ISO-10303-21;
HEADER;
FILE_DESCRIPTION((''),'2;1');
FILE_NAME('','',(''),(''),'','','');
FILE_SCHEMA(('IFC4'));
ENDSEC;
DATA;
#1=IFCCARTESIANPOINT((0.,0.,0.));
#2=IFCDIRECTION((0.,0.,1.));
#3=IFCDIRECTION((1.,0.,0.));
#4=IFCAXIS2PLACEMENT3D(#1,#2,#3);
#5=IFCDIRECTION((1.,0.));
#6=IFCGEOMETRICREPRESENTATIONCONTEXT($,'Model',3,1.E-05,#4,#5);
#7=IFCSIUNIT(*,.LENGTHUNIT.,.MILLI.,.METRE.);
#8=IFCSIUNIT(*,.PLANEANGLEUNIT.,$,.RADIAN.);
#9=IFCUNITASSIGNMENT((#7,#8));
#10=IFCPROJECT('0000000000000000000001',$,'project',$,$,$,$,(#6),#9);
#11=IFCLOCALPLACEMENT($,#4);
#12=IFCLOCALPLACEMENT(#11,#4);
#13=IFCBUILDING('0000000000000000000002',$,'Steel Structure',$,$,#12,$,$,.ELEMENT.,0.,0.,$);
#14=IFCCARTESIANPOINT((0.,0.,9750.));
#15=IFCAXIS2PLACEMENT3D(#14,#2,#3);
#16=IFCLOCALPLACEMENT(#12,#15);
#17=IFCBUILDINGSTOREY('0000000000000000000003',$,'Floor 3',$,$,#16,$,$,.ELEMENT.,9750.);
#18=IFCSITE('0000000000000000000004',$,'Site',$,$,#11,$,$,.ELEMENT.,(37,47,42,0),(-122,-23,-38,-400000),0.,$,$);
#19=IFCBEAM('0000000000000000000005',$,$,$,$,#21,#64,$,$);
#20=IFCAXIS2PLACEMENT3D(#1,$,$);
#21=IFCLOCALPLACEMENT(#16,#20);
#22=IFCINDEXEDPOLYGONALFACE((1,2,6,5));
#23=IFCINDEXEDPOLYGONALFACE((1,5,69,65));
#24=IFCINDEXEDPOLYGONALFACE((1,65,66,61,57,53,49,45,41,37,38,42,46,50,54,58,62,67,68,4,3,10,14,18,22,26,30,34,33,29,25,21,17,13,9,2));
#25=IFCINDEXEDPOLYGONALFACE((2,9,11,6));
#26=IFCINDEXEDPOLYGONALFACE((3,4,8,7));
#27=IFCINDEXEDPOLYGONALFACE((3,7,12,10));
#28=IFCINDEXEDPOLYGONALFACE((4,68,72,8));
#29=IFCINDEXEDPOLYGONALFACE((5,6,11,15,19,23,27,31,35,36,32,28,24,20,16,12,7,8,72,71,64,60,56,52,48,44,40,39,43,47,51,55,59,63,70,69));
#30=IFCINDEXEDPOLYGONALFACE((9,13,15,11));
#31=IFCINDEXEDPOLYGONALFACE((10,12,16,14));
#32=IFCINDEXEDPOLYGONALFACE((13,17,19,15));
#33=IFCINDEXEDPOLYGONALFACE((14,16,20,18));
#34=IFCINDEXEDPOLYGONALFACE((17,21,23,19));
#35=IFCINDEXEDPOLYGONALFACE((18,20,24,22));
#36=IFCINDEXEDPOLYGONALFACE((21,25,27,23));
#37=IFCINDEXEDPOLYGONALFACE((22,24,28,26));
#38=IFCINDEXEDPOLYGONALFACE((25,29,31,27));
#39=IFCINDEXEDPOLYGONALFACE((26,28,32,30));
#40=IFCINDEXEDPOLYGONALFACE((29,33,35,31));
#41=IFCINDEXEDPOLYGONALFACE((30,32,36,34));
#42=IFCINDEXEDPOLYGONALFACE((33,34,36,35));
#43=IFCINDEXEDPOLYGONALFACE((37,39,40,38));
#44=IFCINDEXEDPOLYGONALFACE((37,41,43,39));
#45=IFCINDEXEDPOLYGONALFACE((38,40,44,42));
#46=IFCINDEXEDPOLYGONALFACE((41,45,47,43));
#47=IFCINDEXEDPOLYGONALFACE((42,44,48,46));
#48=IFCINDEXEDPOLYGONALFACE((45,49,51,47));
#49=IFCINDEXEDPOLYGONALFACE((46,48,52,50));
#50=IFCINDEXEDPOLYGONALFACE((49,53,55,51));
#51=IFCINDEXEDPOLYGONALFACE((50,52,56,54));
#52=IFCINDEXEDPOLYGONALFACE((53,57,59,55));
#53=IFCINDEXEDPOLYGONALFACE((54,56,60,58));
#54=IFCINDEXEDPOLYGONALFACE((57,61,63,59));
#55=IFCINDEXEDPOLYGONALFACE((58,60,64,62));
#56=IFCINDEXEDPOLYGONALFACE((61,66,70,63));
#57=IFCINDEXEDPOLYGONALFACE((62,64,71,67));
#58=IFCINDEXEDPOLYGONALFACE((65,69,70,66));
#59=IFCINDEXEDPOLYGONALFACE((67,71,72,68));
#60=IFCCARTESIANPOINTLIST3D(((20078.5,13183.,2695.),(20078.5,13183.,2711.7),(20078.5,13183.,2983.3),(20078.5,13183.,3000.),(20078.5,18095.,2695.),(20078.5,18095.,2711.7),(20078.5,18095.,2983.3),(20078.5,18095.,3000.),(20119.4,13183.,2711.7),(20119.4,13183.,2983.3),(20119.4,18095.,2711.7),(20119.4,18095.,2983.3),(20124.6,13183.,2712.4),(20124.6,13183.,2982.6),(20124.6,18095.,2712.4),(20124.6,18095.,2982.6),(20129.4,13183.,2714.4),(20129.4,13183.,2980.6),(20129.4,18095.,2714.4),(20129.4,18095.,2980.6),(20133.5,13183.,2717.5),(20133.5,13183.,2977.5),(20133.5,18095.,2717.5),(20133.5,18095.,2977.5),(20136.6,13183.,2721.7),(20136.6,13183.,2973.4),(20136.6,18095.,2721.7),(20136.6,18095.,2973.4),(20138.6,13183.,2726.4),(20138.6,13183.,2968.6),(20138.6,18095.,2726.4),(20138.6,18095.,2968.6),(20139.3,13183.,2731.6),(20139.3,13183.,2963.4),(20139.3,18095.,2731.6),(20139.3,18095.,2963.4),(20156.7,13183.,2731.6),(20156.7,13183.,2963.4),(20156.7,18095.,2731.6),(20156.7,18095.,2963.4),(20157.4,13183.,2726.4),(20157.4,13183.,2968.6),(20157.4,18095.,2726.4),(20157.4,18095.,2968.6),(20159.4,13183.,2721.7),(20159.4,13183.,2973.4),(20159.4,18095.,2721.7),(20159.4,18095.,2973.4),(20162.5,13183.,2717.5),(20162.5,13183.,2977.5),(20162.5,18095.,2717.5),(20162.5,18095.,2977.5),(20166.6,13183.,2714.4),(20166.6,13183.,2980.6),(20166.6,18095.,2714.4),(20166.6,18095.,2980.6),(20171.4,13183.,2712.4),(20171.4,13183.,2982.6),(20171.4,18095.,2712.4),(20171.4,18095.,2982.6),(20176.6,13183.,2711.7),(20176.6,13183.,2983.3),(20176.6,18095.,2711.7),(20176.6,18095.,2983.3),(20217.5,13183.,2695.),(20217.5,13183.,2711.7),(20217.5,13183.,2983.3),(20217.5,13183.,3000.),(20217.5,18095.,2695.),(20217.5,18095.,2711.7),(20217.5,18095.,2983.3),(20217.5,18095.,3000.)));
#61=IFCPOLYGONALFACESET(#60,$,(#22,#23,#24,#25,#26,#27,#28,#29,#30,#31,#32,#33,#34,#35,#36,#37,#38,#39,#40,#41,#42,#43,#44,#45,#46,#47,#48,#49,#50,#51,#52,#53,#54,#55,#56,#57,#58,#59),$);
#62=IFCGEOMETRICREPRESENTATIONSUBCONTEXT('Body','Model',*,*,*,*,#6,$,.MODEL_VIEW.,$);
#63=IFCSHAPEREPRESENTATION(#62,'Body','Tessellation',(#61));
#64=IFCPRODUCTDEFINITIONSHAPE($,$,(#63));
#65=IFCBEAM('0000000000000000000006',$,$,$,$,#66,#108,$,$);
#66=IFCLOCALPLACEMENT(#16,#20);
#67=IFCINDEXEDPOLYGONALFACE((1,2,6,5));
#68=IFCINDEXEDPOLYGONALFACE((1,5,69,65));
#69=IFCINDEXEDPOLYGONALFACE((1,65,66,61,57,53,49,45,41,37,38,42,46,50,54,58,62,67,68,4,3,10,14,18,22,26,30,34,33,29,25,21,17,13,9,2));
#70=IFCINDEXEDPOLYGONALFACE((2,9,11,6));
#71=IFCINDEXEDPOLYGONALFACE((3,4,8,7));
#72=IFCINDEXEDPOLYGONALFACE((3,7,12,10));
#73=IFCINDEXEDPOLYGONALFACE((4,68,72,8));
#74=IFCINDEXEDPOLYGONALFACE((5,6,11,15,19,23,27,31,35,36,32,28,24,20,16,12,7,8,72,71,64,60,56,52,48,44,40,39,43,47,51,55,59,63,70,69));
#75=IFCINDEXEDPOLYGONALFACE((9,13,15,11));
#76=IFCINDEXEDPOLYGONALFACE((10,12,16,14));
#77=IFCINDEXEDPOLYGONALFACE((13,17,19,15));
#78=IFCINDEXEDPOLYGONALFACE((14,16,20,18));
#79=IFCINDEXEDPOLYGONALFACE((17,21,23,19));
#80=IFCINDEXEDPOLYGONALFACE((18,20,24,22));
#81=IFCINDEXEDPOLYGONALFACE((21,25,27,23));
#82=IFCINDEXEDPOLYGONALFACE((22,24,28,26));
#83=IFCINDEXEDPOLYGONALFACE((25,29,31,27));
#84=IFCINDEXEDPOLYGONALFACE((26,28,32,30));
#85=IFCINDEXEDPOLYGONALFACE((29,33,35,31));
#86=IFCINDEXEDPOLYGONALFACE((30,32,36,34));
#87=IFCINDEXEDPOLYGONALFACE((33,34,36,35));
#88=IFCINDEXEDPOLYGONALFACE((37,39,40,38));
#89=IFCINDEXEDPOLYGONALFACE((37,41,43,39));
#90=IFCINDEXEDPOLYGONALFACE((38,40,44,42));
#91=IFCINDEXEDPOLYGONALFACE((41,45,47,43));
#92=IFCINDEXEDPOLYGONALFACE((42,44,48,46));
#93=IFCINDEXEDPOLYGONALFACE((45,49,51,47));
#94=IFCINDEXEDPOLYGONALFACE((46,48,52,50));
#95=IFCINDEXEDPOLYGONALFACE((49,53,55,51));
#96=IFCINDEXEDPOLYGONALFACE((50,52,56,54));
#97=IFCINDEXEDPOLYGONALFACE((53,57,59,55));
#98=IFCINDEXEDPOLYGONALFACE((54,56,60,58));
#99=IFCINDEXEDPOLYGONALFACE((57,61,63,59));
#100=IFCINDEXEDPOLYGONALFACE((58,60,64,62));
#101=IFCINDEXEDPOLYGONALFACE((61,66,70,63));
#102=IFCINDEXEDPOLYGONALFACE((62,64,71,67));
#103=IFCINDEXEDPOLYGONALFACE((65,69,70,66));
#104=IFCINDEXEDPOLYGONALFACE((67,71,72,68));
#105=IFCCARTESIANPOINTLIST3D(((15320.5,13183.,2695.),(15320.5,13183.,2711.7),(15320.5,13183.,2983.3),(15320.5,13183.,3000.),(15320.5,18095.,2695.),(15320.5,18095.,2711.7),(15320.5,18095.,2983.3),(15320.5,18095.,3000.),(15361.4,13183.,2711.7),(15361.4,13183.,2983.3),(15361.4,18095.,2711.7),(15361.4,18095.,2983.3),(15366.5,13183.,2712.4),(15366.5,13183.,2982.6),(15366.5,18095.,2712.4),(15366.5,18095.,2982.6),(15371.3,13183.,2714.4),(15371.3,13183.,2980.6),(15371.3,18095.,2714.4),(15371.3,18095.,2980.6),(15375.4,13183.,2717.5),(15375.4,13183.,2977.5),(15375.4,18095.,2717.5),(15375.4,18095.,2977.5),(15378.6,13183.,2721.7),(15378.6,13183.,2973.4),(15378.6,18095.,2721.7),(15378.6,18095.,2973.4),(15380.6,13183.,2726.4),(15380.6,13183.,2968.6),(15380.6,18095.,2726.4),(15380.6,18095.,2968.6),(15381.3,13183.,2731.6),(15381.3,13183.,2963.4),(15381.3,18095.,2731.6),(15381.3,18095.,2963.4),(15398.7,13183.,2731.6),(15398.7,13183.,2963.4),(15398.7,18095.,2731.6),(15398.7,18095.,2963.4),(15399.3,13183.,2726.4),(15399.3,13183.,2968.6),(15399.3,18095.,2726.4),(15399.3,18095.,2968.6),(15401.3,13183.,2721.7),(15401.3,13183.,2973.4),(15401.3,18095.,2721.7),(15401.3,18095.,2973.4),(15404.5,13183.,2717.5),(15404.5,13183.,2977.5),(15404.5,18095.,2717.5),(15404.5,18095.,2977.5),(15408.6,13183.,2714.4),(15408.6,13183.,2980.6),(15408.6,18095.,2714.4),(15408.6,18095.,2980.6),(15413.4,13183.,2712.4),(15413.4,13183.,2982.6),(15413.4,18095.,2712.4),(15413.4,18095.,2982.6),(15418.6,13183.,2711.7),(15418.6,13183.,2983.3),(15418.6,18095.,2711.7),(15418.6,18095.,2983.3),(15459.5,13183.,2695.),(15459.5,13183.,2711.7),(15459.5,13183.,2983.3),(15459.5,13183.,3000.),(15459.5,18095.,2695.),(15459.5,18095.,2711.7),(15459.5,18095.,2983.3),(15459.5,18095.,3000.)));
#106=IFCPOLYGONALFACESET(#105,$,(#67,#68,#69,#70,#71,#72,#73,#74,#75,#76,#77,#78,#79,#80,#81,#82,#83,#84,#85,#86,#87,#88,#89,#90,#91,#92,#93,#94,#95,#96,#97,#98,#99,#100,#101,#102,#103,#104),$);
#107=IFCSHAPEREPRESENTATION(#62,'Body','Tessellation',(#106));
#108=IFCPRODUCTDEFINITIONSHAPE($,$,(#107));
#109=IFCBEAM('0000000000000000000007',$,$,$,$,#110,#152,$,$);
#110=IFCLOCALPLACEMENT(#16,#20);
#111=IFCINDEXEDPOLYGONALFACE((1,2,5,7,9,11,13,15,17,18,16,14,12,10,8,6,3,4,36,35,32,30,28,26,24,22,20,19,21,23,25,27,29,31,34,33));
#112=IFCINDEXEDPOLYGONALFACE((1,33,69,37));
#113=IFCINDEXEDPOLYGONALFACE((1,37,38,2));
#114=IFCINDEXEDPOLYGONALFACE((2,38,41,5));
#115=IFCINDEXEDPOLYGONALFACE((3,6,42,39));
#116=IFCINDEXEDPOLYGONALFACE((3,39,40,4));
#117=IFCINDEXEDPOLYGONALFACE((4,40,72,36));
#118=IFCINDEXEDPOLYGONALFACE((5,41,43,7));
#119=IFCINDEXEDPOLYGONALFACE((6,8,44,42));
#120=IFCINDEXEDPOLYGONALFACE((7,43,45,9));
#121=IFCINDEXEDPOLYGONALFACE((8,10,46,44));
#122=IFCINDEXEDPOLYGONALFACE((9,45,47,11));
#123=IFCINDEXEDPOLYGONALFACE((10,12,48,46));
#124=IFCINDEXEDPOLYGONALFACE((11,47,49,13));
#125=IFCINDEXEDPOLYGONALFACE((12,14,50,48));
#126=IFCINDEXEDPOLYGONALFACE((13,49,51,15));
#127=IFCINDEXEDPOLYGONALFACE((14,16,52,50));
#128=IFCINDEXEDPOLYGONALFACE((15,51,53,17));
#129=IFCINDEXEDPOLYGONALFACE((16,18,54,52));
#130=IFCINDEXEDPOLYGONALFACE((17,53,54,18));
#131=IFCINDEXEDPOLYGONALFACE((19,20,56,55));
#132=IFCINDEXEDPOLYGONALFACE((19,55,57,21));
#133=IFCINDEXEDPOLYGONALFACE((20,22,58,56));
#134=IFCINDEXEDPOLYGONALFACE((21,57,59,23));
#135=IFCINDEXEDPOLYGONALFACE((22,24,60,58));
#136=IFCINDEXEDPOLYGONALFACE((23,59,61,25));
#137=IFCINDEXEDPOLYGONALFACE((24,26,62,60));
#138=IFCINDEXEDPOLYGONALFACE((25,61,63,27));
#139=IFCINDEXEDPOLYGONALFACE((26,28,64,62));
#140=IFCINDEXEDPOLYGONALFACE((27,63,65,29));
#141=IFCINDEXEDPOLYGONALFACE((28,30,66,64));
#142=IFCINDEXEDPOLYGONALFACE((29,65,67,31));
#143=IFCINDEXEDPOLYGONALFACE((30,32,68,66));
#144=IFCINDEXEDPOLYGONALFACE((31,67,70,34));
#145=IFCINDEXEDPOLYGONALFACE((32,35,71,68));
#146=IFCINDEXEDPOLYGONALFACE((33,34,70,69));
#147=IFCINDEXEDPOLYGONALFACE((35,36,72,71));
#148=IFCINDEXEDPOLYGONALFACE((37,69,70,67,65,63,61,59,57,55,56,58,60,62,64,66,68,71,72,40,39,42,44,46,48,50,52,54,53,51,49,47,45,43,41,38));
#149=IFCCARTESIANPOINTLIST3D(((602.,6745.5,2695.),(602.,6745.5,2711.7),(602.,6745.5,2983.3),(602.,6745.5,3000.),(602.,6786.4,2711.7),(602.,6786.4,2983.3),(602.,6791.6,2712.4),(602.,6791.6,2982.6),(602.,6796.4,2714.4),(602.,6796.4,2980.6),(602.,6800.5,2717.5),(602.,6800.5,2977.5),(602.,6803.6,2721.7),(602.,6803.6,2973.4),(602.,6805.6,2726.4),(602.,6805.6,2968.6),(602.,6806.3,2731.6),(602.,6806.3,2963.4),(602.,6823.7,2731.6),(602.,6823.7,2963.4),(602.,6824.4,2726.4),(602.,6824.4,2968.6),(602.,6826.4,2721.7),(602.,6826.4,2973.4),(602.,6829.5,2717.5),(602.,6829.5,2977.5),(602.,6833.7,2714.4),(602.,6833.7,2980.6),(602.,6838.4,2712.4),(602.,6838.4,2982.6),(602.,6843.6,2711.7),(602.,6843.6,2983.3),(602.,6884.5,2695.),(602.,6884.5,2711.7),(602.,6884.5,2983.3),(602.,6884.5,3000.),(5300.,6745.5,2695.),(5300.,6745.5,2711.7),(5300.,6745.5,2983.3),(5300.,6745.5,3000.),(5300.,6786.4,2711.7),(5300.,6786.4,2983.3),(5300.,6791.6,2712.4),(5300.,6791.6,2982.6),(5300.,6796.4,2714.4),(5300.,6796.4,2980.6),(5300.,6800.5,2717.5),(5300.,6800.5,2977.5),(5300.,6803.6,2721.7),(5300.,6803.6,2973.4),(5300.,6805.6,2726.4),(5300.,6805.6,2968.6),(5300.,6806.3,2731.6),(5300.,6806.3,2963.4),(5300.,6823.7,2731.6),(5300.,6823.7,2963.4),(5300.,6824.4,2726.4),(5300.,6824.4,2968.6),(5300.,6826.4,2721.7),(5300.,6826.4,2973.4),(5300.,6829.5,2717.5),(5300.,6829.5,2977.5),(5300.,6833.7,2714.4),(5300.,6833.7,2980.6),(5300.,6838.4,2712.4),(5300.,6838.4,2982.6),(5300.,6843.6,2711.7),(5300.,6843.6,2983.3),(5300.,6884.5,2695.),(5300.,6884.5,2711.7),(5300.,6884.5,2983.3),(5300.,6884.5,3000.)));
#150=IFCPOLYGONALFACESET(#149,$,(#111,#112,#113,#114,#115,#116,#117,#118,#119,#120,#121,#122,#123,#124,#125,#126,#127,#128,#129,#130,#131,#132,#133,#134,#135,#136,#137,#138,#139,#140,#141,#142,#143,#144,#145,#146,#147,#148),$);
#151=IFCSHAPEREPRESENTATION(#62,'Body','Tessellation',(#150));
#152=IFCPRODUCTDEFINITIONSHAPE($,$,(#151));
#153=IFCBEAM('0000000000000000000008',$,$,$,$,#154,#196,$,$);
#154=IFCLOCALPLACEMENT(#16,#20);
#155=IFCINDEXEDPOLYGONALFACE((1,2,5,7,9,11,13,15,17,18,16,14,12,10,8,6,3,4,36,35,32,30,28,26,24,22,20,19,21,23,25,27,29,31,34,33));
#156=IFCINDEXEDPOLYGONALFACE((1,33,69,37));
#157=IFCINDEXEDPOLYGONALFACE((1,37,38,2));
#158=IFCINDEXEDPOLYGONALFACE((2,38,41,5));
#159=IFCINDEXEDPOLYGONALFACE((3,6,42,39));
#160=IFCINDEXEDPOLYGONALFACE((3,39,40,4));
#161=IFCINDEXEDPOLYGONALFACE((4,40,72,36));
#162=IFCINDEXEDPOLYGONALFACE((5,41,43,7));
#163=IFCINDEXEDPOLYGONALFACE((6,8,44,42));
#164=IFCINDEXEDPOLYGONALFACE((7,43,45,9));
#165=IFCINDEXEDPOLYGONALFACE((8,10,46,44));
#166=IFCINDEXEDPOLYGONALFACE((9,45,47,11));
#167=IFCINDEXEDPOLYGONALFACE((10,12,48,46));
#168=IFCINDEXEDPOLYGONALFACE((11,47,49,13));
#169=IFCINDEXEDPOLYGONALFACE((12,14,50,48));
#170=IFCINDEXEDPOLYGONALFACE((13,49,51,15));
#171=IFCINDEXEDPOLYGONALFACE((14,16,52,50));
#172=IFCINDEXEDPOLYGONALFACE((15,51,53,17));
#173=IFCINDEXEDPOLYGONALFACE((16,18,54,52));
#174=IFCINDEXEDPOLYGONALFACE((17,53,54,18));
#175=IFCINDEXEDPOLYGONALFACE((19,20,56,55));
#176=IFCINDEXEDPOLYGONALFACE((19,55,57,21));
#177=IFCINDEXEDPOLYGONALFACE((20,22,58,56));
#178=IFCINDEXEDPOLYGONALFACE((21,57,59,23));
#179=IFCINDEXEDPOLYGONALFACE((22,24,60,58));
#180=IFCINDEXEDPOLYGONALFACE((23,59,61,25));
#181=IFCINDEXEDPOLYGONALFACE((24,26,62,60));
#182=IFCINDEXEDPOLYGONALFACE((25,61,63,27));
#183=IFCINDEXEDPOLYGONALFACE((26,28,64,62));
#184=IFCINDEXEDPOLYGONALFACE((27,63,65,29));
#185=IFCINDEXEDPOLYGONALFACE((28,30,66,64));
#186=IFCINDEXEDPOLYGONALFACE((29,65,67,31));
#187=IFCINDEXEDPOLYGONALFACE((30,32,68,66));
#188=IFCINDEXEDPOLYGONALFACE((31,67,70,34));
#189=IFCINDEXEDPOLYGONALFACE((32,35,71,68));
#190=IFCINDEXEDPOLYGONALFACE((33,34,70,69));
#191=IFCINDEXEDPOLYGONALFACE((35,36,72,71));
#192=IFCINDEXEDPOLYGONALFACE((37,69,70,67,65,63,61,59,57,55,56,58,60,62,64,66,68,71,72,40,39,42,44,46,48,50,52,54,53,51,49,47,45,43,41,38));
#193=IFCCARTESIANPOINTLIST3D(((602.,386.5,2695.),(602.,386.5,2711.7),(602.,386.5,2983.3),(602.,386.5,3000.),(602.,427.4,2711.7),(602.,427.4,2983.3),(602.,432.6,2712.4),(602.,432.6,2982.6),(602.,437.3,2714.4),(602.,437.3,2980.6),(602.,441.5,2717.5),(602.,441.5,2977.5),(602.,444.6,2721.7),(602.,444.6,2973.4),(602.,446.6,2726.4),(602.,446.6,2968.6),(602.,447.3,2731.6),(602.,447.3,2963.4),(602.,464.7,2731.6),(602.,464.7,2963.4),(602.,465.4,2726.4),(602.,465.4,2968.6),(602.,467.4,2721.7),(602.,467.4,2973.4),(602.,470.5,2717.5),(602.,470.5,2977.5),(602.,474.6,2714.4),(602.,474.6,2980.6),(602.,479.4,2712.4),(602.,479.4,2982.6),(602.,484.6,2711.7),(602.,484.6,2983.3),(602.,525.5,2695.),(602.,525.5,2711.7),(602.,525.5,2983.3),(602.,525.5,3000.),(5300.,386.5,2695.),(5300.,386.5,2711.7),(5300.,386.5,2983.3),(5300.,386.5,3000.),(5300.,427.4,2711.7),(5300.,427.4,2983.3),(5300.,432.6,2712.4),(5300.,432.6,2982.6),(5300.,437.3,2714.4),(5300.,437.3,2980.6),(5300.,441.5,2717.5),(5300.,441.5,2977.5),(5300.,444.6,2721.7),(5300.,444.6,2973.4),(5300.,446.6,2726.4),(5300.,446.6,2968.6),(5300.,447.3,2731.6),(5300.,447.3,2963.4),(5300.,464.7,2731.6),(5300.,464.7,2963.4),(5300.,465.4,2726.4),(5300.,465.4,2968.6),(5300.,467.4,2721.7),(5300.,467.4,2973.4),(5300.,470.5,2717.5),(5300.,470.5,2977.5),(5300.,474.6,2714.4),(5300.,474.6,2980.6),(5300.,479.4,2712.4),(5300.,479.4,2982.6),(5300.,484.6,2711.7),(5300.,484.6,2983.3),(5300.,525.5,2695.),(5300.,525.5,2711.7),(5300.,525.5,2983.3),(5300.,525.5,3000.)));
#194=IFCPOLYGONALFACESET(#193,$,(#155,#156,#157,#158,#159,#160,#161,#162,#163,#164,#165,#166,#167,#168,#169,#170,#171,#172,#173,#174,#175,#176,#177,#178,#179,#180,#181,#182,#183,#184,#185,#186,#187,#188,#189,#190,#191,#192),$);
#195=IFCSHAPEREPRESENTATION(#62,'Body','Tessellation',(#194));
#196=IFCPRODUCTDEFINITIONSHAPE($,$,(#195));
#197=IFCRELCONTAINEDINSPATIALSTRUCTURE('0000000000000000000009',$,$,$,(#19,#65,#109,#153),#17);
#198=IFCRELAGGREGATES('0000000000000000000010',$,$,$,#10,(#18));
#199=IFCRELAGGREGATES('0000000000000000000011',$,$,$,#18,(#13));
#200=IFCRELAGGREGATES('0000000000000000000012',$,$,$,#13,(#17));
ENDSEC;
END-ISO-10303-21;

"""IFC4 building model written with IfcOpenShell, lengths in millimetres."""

from ifc_helpers import new_model, si_unit, direction, frame, origin_with_axes, origin_2d_with_axis, place, context, subcontext, project, spatial, i_section, extrude, element, save


model = new_model("IFC4")

# Units and contexts
model_context = context("Model", 3, precision=1e-05, world=origin_with_axes(), true_north=direction((1.0, 0.0)))
body_context = subcontext(model_context, "Body", "Model", "MODEL_VIEW")
ifc_project = project(units=[si_unit("LENGTHUNIT", "METRE", prefix="MILLI"), si_unit("PLANEANGLEUNIT", "RADIAN")], contexts=[model_context])

# Site, building, storey
site_placement = place(None, origin_with_axes())
site = spatial("IfcSite", under=ifc_project, at=site_placement, Name="Site", CompositionType="ELEMENT", RefLatitude=(37, 47, 42, 0), RefLongitude=(-122, -23, -38, -400000), RefElevation=0.0)
building_placement = place(site_placement, origin_with_axes())
building = spatial("IfcBuilding", under=site, at=building_placement, Name="Steel Structure", CompositionType="ELEMENT", ElevationOfRefHeight=0.0, ElevationOfTerrain=0.0)
storey_placement = place(building_placement, frame((0.0, 0.0, 9750.0), z_axis=(0.0, 0.0, 1.0), x_axis=(1.0, 0.0, 0.0)))
storey = spatial("IfcBuildingStorey", under=building, at=storey_placement, Name="Floor 3", CompositionType="ELEMENT", Elevation=9750.0)

# Beams
for number, where, z_axis, x_axis in (
    (1, (20148.0, 18095.0, 2695.0), (0.0, -1.0, 0.0), (1.0, 0.0, 0.0)),
    (2, (15390.0, 18095.0, 2695.0), (0.0, -1.0, 0.0), (1.0, 0.0, 0.0)),
):
    element("IfcBeam", number, at=place(storey_placement, frame(where, z_axis=z_axis, x_axis=x_axis)), inside=storey, context=body_context, shape_type="SweptSolid", body=[
        extrude(i_section(OverallWidth=139.0, OverallDepth=305.0, WebThickness=17.4, FlangeThickness=16.7, FilletRadius=19.9, at=origin_2d_with_axis()), frame((0.0, 152.5, 0.0), z_axis=(0.0, 0.0, 1.0), x_axis=(1.0, 0.0, 0.0)), (0.0, 0.0, 1.0), 4912.0),
    ])
beam_1_placement = place(storey_placement, frame((5300.0, 6815.0, 2695.0), z_axis=(-1.0, 0.0, 0.0), x_axis=(0.0, -1.0, 0.0)))
element("IfcBeam", 3, at=beam_1_placement, inside=storey, context=body_context, shape_type="SweptSolid", body=[
    extrude(i_section(OverallWidth=139.0, OverallDepth=305.0, WebThickness=17.4, FlangeThickness=16.7, FilletRadius=19.9, at=origin_2d_with_axis()), frame((0.0, 152.5, 0.0), z_axis=(0.0, 0.0, 1.0), x_axis=(1.0, 0.0, 0.0)), (0.0, 0.0, 1.0), 4698.0),
])
for number, where, z_axis, x_axis in (
    (4, (602.0, 456.0, 2695.0), (1.0, 0.0, 0.0), (0.0, 1.0, 0.0)),
):
    element("IfcBeam", number, at=place(storey_placement, frame(where, z_axis=z_axis, x_axis=x_axis)), inside=storey, context=body_context, shape_type="SweptSolid", body=[
        extrude(i_section(OverallWidth=139.0, OverallDepth=305.0, WebThickness=17.4, FlangeThickness=16.7, FilletRadius=19.9, at=origin_2d_with_axis()), frame((0.0, 152.5, 0.0), z_axis=(0.0, 0.0, 1.0), x_axis=(1.0, 0.0, 0.0)), (0.0, 0.0, 1.0), 4698.0),
    ])

save(model, "model.ifc")
